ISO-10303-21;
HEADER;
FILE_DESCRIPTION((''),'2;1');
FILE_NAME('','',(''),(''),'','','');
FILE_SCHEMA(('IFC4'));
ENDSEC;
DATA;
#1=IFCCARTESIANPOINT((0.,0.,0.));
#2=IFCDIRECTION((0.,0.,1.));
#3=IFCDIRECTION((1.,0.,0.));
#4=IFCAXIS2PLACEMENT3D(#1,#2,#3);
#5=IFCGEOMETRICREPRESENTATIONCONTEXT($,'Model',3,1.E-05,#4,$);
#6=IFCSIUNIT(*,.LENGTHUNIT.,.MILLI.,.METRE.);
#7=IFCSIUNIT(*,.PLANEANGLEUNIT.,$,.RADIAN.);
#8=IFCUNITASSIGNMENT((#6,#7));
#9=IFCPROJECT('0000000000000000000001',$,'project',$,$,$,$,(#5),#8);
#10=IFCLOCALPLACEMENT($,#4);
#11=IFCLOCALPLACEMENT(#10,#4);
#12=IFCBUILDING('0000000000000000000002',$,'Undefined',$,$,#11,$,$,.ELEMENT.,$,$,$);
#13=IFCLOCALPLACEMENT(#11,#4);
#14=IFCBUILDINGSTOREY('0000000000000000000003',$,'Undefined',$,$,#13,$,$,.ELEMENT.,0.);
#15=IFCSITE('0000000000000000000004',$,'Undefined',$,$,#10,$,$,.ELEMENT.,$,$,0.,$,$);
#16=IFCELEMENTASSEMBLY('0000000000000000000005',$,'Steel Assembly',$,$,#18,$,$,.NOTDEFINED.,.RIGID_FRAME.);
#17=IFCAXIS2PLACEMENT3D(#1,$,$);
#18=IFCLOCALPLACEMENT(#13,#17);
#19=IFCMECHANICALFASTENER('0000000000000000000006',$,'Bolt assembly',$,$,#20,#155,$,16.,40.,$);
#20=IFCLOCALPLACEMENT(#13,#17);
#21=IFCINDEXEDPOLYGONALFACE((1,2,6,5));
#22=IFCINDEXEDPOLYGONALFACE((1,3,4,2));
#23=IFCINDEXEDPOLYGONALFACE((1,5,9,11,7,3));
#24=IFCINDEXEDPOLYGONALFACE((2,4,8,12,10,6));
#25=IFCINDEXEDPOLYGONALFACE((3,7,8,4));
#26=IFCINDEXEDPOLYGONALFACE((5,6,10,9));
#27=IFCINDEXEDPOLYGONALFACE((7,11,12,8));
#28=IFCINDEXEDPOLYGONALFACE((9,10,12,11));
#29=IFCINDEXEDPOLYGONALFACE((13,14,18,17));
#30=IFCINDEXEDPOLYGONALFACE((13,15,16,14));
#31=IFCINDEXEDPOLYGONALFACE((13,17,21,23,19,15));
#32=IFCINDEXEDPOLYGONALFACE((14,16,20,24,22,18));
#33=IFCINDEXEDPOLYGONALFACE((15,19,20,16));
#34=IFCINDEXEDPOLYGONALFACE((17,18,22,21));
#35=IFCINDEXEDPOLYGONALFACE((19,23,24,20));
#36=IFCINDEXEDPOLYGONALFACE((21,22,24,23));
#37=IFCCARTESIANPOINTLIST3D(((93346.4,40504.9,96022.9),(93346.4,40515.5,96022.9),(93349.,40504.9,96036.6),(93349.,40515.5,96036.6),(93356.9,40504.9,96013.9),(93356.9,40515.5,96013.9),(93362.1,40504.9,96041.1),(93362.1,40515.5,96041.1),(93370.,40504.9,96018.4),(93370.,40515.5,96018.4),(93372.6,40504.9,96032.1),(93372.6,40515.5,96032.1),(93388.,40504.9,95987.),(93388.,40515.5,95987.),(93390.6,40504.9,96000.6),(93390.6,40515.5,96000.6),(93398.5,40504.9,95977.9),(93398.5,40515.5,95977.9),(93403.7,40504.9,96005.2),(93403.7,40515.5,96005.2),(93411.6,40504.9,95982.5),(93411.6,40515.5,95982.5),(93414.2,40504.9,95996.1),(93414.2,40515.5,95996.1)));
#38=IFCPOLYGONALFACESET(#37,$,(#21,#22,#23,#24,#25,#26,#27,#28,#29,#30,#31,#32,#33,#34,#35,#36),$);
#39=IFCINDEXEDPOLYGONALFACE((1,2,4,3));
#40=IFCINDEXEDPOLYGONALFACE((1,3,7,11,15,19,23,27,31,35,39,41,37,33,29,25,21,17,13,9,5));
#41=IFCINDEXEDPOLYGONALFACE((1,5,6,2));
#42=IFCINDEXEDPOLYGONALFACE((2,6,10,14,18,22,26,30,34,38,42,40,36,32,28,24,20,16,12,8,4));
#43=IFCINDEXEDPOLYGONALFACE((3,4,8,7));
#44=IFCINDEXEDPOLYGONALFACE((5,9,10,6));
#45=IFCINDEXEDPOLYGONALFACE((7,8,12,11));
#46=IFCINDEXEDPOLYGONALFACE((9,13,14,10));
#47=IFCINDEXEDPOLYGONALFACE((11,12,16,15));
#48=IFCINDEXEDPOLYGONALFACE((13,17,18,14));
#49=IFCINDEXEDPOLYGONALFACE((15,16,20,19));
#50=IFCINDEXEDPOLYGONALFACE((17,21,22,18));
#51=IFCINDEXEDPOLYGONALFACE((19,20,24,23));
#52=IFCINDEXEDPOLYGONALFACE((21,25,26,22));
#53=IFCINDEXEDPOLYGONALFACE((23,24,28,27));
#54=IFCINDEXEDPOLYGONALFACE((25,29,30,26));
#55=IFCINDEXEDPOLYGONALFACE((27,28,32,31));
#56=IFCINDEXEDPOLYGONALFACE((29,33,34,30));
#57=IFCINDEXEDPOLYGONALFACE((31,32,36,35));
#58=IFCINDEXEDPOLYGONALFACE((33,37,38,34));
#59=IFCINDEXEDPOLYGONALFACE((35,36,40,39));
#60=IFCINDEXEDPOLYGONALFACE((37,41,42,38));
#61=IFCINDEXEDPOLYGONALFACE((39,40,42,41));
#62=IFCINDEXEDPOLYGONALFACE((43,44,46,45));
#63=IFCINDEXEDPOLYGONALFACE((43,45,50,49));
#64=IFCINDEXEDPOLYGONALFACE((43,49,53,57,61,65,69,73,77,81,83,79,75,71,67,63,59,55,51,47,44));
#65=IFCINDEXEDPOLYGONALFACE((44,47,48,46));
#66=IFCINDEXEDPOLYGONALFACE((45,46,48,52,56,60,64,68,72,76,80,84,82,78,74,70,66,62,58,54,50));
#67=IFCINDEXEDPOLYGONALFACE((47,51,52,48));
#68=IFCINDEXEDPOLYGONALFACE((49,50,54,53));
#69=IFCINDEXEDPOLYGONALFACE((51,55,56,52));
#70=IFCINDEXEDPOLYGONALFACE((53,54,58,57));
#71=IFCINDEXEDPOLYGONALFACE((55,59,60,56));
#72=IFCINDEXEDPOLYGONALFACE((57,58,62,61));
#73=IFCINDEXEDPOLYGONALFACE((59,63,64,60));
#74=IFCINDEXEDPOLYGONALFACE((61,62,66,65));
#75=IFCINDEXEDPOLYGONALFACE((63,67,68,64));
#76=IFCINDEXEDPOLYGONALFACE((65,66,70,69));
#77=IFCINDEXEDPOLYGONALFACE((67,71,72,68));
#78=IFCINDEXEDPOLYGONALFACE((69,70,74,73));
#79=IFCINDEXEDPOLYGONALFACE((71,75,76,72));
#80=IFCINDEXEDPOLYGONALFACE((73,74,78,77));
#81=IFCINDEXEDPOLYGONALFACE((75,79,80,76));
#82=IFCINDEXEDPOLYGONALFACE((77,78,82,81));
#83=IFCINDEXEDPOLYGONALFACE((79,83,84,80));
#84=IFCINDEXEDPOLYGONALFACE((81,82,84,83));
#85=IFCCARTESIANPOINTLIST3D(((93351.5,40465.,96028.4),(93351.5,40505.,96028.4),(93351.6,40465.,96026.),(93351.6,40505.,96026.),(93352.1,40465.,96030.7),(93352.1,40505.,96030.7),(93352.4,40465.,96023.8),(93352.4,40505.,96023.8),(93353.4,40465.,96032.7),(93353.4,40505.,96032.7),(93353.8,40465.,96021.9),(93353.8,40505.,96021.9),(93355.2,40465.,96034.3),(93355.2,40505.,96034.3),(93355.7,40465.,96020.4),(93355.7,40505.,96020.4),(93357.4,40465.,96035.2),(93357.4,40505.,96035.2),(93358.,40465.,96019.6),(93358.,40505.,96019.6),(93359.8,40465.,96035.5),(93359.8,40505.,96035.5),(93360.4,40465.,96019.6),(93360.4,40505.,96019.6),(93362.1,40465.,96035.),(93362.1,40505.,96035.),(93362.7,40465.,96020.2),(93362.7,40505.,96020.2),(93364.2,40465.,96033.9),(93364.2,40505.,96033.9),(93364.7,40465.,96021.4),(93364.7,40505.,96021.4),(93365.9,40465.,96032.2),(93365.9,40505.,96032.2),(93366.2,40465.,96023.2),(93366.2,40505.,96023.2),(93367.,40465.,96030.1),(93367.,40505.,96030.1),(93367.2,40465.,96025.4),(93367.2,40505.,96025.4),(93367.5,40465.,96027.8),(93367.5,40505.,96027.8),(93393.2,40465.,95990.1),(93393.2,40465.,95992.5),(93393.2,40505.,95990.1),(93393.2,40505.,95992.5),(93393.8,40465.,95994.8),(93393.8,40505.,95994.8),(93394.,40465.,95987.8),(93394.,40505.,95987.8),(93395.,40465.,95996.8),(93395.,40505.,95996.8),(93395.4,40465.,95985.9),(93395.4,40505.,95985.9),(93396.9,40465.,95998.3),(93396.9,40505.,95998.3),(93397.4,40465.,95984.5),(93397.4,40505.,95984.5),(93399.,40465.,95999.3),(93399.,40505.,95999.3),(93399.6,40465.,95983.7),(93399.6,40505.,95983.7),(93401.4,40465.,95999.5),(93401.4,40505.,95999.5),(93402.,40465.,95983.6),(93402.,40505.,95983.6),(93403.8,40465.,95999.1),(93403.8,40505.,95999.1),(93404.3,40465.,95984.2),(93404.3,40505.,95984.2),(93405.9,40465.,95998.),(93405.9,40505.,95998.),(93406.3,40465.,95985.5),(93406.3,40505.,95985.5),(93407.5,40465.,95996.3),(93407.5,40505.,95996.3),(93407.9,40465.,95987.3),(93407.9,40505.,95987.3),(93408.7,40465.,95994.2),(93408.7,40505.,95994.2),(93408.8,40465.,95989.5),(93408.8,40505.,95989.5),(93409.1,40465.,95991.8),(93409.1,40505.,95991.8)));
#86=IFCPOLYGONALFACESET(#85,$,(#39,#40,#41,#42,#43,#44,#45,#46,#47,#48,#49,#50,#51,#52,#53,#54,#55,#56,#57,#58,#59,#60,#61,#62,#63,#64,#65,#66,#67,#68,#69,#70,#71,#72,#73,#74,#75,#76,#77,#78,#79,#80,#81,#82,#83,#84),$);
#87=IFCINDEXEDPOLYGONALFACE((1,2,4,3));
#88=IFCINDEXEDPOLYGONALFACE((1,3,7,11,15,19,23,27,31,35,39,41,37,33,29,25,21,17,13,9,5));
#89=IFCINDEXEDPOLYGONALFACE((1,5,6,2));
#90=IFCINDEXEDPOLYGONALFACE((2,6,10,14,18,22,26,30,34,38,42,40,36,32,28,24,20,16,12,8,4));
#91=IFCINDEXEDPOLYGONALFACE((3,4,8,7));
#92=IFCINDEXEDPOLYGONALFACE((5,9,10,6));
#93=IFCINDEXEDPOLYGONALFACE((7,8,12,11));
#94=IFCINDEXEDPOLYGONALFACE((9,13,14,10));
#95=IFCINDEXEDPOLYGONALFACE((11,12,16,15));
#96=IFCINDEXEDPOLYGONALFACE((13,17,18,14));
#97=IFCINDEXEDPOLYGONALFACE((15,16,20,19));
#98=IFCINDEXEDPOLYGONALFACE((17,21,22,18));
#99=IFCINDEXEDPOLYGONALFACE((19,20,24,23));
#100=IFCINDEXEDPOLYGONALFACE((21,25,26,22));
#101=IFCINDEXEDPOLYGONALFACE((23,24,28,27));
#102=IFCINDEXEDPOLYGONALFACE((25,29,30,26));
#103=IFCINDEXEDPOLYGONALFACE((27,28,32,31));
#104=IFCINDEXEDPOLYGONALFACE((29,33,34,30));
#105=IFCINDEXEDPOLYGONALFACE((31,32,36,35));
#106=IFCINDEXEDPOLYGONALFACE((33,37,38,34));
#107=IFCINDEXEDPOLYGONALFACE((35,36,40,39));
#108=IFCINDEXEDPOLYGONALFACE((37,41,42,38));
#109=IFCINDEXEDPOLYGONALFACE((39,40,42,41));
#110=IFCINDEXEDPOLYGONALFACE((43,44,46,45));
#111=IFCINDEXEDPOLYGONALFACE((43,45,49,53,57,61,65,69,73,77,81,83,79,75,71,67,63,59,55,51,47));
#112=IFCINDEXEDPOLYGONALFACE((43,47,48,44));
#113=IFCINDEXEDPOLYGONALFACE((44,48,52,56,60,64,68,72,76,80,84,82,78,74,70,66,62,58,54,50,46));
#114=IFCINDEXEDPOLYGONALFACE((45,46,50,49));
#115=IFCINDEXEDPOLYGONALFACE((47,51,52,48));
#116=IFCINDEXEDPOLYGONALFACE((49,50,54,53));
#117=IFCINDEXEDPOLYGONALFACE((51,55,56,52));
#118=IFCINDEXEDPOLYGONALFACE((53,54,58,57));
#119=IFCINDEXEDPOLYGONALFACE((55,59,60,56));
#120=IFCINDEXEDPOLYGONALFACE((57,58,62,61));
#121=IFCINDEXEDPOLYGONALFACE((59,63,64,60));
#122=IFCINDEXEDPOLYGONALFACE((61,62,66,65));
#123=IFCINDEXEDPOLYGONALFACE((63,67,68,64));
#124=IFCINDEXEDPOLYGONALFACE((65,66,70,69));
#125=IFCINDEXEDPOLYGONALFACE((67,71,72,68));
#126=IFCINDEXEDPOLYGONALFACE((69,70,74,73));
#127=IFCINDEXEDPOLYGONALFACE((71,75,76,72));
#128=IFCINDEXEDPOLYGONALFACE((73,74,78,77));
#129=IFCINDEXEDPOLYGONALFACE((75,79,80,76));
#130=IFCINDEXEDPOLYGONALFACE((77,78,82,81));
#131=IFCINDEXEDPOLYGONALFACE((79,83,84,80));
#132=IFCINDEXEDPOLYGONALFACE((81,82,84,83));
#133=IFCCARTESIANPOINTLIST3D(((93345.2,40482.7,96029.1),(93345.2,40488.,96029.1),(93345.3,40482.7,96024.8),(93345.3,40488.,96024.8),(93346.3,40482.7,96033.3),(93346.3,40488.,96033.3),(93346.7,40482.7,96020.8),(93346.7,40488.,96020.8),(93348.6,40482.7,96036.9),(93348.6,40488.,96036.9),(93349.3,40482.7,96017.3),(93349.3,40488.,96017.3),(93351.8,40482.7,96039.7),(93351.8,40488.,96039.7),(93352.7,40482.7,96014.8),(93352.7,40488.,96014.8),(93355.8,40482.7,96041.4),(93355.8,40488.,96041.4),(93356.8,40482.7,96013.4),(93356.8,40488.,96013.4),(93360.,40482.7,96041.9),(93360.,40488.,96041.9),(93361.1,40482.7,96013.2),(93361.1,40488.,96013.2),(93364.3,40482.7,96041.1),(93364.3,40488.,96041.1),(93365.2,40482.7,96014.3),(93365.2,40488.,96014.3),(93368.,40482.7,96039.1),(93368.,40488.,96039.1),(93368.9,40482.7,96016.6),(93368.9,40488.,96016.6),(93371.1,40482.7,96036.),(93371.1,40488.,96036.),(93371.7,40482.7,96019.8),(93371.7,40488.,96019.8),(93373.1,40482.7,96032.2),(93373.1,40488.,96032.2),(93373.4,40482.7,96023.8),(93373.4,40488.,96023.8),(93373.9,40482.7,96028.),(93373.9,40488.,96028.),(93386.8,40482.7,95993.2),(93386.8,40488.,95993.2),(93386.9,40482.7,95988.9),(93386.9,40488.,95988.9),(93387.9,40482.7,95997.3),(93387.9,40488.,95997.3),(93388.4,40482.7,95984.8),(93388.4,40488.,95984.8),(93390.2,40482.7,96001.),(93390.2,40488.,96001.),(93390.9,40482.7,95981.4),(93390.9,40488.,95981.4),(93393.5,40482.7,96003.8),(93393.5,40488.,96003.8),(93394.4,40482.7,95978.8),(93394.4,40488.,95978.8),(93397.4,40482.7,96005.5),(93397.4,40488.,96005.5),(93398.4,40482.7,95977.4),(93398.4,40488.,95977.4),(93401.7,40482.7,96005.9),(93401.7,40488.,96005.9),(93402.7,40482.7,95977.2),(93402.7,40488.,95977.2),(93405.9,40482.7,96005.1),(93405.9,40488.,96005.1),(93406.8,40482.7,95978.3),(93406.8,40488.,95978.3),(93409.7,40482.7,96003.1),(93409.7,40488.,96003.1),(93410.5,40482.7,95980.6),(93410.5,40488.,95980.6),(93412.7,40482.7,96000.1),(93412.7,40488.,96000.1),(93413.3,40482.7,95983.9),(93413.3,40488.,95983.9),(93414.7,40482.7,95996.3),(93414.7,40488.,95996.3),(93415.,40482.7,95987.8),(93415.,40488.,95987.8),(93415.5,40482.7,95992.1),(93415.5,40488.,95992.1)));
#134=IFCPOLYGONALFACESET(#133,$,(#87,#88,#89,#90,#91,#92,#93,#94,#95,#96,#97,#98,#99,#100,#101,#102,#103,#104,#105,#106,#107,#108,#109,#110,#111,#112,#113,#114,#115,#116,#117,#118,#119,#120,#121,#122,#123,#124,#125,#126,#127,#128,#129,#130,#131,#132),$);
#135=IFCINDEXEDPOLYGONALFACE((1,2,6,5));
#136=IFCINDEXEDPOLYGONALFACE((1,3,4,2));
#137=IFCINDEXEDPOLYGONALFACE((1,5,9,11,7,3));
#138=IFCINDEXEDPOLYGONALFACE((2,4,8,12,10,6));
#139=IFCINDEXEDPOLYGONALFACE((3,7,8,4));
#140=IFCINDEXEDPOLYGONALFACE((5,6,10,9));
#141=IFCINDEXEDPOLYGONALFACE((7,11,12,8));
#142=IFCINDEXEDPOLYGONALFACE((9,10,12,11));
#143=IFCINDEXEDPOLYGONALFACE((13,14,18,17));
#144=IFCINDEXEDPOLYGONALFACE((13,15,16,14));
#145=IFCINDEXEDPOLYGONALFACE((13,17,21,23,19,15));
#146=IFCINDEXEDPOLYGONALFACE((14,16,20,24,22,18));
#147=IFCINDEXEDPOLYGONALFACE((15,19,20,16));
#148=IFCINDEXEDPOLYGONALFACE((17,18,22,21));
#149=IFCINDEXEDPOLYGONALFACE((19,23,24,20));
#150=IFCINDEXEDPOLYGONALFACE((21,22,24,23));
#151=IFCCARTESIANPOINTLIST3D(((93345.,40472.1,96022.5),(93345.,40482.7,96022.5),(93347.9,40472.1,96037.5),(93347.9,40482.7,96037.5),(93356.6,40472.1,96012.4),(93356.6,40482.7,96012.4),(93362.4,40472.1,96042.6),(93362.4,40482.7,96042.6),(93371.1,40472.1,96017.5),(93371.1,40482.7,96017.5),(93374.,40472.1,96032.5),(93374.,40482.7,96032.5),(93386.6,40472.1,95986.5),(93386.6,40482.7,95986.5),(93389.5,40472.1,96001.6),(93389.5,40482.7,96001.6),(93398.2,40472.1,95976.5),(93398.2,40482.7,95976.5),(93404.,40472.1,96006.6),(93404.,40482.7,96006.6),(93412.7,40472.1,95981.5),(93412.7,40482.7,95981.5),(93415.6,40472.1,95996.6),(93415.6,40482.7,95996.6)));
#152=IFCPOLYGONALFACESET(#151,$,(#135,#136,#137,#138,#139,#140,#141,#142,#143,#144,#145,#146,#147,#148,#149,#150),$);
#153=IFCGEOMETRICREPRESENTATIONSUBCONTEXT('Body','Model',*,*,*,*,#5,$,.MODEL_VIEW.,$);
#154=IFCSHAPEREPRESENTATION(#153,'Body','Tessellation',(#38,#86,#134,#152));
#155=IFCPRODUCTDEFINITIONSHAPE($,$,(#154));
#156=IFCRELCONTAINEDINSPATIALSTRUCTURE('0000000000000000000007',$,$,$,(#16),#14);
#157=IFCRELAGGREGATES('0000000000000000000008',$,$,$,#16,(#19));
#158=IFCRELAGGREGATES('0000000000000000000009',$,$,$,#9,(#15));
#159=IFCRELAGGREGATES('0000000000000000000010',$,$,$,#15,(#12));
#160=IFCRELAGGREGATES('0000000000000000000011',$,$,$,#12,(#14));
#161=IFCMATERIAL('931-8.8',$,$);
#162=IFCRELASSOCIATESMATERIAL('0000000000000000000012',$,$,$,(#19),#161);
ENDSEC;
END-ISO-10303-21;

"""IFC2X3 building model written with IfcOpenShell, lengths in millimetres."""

from ifc_helpers import new_model, si_unit, frame, origin_with_axes, origin_2d_with_axis, place, context, subcontext, project, spatial, polyline, circle, outline, extrude, source, transform, mapped, material, element, aggregate, save


model = new_model("IFC2X3")

# Units and contexts
model_context = context("Model", 3, precision=1e-05, world=origin_with_axes())
body_context = subcontext(model_context, "Body", "Model", "MODEL_VIEW")
ifc_project = project(units=[si_unit("LENGTHUNIT", "METRE", prefix="MILLI"), si_unit("PLANEANGLEUNIT", "RADIAN")], contexts=[model_context])

# Site, building, storey
site_placement = place(None, origin_with_axes())
site = spatial("IfcSite", under=ifc_project, at=site_placement, Name="Undefined", CompositionType="ELEMENT", RefElevation=0.0)
building_placement = place(site_placement, origin_with_axes())
building = spatial("IfcBuilding", under=site, at=building_placement, Name="Undefined", CompositionType="ELEMENT")
storey_placement = place(building_placement, origin_with_axes())
storey = spatial("IfcBuildingStorey", under=building, at=storey_placement, Name="Undefined", CompositionType="ELEMENT", Elevation=0.0)

# Element assembly, mechanical fastener
assembly_1_placement = place(storey_placement, origin_with_axes())
assembly_1 = element("IfcElementAssembly", 1, at=assembly_1_placement, inside=storey, Name="Steel Assembly", AssemblyPlace="NOTDEFINED", PredefinedType="RIGID_FRAME")
ifc_material_1 = material(Name="931-8.8")
shared_shape_1 = source(origin_with_axes(), body_context, "Body", "SweptSolid", [
    extrude(outline(polyline([(13.9, 0.0), (6.9, 12.0), (-6.9, 12.0), (-13.9, 0.0), (-6.9, -12.0), (6.9, -12.0), (13.9, 0.0)])), frame((0.0, -15.6, 0.0), z_axis=(0.0, 1.0, 0.0), x_axis=(1.0, 0.0, 0.0)), (0.0, 0.0, 1.0), 10.6),
    extrude(circle(Radius=8.0, at=origin_2d_with_axis()), frame((0.0, -5.0, 0.0), z_axis=(0.0, 1.0, 0.0), x_axis=(1.0, 0.0, 0.0)), (0.0, 0.0, 1.0), 40.0),
    extrude(circle(Radius=14.4, at=origin_2d_with_axis()), frame((0.0, 12.0, 0.0), z_axis=(0.0, 1.0, 0.0), x_axis=(1.0, 0.0, 0.0)), (0.0, 0.0, 1.0), 5.3),
    extrude(outline(polyline([(15.3, 0.0), (7.7, 13.3), (-7.7, 13.3), (-15.3, 0.0), (-7.7, -13.3), (7.7, -13.3), (15.3, 0.0)])), frame((0.0, 17.3, 0.0), z_axis=(0.0, 1.0, 0.0), x_axis=(1.0, 0.0, 0.0)), (0.0, 0.0, 1.0), 10.6),
])
mechanical_fastener_1_placement = place(assembly_1_placement, frame((93401.1, 40500.0, 95991.6), z_axis=(0.653592, 0.0, 0.756847), x_axis=(-0.756847, 0.0, 0.653592)))
mechanical_fastener_1 = element("IfcMechanicalFastener", 2, at=mechanical_fastener_1_placement, material=ifc_material_1, Name="Bolt assembly", NominalDiameter=16.0, NominalLength=40.0, context=body_context, shape_type="MappedRepresentation", body=[
    mapped(shared_shape_1, transform((0.0, 0.0, 0.0))),
    mapped(shared_shape_1, transform((55.0, 0.0, 0.0))),
])

aggregate(assembly_1, [mechanical_fastener_1])

save(model, "model.ifc")
